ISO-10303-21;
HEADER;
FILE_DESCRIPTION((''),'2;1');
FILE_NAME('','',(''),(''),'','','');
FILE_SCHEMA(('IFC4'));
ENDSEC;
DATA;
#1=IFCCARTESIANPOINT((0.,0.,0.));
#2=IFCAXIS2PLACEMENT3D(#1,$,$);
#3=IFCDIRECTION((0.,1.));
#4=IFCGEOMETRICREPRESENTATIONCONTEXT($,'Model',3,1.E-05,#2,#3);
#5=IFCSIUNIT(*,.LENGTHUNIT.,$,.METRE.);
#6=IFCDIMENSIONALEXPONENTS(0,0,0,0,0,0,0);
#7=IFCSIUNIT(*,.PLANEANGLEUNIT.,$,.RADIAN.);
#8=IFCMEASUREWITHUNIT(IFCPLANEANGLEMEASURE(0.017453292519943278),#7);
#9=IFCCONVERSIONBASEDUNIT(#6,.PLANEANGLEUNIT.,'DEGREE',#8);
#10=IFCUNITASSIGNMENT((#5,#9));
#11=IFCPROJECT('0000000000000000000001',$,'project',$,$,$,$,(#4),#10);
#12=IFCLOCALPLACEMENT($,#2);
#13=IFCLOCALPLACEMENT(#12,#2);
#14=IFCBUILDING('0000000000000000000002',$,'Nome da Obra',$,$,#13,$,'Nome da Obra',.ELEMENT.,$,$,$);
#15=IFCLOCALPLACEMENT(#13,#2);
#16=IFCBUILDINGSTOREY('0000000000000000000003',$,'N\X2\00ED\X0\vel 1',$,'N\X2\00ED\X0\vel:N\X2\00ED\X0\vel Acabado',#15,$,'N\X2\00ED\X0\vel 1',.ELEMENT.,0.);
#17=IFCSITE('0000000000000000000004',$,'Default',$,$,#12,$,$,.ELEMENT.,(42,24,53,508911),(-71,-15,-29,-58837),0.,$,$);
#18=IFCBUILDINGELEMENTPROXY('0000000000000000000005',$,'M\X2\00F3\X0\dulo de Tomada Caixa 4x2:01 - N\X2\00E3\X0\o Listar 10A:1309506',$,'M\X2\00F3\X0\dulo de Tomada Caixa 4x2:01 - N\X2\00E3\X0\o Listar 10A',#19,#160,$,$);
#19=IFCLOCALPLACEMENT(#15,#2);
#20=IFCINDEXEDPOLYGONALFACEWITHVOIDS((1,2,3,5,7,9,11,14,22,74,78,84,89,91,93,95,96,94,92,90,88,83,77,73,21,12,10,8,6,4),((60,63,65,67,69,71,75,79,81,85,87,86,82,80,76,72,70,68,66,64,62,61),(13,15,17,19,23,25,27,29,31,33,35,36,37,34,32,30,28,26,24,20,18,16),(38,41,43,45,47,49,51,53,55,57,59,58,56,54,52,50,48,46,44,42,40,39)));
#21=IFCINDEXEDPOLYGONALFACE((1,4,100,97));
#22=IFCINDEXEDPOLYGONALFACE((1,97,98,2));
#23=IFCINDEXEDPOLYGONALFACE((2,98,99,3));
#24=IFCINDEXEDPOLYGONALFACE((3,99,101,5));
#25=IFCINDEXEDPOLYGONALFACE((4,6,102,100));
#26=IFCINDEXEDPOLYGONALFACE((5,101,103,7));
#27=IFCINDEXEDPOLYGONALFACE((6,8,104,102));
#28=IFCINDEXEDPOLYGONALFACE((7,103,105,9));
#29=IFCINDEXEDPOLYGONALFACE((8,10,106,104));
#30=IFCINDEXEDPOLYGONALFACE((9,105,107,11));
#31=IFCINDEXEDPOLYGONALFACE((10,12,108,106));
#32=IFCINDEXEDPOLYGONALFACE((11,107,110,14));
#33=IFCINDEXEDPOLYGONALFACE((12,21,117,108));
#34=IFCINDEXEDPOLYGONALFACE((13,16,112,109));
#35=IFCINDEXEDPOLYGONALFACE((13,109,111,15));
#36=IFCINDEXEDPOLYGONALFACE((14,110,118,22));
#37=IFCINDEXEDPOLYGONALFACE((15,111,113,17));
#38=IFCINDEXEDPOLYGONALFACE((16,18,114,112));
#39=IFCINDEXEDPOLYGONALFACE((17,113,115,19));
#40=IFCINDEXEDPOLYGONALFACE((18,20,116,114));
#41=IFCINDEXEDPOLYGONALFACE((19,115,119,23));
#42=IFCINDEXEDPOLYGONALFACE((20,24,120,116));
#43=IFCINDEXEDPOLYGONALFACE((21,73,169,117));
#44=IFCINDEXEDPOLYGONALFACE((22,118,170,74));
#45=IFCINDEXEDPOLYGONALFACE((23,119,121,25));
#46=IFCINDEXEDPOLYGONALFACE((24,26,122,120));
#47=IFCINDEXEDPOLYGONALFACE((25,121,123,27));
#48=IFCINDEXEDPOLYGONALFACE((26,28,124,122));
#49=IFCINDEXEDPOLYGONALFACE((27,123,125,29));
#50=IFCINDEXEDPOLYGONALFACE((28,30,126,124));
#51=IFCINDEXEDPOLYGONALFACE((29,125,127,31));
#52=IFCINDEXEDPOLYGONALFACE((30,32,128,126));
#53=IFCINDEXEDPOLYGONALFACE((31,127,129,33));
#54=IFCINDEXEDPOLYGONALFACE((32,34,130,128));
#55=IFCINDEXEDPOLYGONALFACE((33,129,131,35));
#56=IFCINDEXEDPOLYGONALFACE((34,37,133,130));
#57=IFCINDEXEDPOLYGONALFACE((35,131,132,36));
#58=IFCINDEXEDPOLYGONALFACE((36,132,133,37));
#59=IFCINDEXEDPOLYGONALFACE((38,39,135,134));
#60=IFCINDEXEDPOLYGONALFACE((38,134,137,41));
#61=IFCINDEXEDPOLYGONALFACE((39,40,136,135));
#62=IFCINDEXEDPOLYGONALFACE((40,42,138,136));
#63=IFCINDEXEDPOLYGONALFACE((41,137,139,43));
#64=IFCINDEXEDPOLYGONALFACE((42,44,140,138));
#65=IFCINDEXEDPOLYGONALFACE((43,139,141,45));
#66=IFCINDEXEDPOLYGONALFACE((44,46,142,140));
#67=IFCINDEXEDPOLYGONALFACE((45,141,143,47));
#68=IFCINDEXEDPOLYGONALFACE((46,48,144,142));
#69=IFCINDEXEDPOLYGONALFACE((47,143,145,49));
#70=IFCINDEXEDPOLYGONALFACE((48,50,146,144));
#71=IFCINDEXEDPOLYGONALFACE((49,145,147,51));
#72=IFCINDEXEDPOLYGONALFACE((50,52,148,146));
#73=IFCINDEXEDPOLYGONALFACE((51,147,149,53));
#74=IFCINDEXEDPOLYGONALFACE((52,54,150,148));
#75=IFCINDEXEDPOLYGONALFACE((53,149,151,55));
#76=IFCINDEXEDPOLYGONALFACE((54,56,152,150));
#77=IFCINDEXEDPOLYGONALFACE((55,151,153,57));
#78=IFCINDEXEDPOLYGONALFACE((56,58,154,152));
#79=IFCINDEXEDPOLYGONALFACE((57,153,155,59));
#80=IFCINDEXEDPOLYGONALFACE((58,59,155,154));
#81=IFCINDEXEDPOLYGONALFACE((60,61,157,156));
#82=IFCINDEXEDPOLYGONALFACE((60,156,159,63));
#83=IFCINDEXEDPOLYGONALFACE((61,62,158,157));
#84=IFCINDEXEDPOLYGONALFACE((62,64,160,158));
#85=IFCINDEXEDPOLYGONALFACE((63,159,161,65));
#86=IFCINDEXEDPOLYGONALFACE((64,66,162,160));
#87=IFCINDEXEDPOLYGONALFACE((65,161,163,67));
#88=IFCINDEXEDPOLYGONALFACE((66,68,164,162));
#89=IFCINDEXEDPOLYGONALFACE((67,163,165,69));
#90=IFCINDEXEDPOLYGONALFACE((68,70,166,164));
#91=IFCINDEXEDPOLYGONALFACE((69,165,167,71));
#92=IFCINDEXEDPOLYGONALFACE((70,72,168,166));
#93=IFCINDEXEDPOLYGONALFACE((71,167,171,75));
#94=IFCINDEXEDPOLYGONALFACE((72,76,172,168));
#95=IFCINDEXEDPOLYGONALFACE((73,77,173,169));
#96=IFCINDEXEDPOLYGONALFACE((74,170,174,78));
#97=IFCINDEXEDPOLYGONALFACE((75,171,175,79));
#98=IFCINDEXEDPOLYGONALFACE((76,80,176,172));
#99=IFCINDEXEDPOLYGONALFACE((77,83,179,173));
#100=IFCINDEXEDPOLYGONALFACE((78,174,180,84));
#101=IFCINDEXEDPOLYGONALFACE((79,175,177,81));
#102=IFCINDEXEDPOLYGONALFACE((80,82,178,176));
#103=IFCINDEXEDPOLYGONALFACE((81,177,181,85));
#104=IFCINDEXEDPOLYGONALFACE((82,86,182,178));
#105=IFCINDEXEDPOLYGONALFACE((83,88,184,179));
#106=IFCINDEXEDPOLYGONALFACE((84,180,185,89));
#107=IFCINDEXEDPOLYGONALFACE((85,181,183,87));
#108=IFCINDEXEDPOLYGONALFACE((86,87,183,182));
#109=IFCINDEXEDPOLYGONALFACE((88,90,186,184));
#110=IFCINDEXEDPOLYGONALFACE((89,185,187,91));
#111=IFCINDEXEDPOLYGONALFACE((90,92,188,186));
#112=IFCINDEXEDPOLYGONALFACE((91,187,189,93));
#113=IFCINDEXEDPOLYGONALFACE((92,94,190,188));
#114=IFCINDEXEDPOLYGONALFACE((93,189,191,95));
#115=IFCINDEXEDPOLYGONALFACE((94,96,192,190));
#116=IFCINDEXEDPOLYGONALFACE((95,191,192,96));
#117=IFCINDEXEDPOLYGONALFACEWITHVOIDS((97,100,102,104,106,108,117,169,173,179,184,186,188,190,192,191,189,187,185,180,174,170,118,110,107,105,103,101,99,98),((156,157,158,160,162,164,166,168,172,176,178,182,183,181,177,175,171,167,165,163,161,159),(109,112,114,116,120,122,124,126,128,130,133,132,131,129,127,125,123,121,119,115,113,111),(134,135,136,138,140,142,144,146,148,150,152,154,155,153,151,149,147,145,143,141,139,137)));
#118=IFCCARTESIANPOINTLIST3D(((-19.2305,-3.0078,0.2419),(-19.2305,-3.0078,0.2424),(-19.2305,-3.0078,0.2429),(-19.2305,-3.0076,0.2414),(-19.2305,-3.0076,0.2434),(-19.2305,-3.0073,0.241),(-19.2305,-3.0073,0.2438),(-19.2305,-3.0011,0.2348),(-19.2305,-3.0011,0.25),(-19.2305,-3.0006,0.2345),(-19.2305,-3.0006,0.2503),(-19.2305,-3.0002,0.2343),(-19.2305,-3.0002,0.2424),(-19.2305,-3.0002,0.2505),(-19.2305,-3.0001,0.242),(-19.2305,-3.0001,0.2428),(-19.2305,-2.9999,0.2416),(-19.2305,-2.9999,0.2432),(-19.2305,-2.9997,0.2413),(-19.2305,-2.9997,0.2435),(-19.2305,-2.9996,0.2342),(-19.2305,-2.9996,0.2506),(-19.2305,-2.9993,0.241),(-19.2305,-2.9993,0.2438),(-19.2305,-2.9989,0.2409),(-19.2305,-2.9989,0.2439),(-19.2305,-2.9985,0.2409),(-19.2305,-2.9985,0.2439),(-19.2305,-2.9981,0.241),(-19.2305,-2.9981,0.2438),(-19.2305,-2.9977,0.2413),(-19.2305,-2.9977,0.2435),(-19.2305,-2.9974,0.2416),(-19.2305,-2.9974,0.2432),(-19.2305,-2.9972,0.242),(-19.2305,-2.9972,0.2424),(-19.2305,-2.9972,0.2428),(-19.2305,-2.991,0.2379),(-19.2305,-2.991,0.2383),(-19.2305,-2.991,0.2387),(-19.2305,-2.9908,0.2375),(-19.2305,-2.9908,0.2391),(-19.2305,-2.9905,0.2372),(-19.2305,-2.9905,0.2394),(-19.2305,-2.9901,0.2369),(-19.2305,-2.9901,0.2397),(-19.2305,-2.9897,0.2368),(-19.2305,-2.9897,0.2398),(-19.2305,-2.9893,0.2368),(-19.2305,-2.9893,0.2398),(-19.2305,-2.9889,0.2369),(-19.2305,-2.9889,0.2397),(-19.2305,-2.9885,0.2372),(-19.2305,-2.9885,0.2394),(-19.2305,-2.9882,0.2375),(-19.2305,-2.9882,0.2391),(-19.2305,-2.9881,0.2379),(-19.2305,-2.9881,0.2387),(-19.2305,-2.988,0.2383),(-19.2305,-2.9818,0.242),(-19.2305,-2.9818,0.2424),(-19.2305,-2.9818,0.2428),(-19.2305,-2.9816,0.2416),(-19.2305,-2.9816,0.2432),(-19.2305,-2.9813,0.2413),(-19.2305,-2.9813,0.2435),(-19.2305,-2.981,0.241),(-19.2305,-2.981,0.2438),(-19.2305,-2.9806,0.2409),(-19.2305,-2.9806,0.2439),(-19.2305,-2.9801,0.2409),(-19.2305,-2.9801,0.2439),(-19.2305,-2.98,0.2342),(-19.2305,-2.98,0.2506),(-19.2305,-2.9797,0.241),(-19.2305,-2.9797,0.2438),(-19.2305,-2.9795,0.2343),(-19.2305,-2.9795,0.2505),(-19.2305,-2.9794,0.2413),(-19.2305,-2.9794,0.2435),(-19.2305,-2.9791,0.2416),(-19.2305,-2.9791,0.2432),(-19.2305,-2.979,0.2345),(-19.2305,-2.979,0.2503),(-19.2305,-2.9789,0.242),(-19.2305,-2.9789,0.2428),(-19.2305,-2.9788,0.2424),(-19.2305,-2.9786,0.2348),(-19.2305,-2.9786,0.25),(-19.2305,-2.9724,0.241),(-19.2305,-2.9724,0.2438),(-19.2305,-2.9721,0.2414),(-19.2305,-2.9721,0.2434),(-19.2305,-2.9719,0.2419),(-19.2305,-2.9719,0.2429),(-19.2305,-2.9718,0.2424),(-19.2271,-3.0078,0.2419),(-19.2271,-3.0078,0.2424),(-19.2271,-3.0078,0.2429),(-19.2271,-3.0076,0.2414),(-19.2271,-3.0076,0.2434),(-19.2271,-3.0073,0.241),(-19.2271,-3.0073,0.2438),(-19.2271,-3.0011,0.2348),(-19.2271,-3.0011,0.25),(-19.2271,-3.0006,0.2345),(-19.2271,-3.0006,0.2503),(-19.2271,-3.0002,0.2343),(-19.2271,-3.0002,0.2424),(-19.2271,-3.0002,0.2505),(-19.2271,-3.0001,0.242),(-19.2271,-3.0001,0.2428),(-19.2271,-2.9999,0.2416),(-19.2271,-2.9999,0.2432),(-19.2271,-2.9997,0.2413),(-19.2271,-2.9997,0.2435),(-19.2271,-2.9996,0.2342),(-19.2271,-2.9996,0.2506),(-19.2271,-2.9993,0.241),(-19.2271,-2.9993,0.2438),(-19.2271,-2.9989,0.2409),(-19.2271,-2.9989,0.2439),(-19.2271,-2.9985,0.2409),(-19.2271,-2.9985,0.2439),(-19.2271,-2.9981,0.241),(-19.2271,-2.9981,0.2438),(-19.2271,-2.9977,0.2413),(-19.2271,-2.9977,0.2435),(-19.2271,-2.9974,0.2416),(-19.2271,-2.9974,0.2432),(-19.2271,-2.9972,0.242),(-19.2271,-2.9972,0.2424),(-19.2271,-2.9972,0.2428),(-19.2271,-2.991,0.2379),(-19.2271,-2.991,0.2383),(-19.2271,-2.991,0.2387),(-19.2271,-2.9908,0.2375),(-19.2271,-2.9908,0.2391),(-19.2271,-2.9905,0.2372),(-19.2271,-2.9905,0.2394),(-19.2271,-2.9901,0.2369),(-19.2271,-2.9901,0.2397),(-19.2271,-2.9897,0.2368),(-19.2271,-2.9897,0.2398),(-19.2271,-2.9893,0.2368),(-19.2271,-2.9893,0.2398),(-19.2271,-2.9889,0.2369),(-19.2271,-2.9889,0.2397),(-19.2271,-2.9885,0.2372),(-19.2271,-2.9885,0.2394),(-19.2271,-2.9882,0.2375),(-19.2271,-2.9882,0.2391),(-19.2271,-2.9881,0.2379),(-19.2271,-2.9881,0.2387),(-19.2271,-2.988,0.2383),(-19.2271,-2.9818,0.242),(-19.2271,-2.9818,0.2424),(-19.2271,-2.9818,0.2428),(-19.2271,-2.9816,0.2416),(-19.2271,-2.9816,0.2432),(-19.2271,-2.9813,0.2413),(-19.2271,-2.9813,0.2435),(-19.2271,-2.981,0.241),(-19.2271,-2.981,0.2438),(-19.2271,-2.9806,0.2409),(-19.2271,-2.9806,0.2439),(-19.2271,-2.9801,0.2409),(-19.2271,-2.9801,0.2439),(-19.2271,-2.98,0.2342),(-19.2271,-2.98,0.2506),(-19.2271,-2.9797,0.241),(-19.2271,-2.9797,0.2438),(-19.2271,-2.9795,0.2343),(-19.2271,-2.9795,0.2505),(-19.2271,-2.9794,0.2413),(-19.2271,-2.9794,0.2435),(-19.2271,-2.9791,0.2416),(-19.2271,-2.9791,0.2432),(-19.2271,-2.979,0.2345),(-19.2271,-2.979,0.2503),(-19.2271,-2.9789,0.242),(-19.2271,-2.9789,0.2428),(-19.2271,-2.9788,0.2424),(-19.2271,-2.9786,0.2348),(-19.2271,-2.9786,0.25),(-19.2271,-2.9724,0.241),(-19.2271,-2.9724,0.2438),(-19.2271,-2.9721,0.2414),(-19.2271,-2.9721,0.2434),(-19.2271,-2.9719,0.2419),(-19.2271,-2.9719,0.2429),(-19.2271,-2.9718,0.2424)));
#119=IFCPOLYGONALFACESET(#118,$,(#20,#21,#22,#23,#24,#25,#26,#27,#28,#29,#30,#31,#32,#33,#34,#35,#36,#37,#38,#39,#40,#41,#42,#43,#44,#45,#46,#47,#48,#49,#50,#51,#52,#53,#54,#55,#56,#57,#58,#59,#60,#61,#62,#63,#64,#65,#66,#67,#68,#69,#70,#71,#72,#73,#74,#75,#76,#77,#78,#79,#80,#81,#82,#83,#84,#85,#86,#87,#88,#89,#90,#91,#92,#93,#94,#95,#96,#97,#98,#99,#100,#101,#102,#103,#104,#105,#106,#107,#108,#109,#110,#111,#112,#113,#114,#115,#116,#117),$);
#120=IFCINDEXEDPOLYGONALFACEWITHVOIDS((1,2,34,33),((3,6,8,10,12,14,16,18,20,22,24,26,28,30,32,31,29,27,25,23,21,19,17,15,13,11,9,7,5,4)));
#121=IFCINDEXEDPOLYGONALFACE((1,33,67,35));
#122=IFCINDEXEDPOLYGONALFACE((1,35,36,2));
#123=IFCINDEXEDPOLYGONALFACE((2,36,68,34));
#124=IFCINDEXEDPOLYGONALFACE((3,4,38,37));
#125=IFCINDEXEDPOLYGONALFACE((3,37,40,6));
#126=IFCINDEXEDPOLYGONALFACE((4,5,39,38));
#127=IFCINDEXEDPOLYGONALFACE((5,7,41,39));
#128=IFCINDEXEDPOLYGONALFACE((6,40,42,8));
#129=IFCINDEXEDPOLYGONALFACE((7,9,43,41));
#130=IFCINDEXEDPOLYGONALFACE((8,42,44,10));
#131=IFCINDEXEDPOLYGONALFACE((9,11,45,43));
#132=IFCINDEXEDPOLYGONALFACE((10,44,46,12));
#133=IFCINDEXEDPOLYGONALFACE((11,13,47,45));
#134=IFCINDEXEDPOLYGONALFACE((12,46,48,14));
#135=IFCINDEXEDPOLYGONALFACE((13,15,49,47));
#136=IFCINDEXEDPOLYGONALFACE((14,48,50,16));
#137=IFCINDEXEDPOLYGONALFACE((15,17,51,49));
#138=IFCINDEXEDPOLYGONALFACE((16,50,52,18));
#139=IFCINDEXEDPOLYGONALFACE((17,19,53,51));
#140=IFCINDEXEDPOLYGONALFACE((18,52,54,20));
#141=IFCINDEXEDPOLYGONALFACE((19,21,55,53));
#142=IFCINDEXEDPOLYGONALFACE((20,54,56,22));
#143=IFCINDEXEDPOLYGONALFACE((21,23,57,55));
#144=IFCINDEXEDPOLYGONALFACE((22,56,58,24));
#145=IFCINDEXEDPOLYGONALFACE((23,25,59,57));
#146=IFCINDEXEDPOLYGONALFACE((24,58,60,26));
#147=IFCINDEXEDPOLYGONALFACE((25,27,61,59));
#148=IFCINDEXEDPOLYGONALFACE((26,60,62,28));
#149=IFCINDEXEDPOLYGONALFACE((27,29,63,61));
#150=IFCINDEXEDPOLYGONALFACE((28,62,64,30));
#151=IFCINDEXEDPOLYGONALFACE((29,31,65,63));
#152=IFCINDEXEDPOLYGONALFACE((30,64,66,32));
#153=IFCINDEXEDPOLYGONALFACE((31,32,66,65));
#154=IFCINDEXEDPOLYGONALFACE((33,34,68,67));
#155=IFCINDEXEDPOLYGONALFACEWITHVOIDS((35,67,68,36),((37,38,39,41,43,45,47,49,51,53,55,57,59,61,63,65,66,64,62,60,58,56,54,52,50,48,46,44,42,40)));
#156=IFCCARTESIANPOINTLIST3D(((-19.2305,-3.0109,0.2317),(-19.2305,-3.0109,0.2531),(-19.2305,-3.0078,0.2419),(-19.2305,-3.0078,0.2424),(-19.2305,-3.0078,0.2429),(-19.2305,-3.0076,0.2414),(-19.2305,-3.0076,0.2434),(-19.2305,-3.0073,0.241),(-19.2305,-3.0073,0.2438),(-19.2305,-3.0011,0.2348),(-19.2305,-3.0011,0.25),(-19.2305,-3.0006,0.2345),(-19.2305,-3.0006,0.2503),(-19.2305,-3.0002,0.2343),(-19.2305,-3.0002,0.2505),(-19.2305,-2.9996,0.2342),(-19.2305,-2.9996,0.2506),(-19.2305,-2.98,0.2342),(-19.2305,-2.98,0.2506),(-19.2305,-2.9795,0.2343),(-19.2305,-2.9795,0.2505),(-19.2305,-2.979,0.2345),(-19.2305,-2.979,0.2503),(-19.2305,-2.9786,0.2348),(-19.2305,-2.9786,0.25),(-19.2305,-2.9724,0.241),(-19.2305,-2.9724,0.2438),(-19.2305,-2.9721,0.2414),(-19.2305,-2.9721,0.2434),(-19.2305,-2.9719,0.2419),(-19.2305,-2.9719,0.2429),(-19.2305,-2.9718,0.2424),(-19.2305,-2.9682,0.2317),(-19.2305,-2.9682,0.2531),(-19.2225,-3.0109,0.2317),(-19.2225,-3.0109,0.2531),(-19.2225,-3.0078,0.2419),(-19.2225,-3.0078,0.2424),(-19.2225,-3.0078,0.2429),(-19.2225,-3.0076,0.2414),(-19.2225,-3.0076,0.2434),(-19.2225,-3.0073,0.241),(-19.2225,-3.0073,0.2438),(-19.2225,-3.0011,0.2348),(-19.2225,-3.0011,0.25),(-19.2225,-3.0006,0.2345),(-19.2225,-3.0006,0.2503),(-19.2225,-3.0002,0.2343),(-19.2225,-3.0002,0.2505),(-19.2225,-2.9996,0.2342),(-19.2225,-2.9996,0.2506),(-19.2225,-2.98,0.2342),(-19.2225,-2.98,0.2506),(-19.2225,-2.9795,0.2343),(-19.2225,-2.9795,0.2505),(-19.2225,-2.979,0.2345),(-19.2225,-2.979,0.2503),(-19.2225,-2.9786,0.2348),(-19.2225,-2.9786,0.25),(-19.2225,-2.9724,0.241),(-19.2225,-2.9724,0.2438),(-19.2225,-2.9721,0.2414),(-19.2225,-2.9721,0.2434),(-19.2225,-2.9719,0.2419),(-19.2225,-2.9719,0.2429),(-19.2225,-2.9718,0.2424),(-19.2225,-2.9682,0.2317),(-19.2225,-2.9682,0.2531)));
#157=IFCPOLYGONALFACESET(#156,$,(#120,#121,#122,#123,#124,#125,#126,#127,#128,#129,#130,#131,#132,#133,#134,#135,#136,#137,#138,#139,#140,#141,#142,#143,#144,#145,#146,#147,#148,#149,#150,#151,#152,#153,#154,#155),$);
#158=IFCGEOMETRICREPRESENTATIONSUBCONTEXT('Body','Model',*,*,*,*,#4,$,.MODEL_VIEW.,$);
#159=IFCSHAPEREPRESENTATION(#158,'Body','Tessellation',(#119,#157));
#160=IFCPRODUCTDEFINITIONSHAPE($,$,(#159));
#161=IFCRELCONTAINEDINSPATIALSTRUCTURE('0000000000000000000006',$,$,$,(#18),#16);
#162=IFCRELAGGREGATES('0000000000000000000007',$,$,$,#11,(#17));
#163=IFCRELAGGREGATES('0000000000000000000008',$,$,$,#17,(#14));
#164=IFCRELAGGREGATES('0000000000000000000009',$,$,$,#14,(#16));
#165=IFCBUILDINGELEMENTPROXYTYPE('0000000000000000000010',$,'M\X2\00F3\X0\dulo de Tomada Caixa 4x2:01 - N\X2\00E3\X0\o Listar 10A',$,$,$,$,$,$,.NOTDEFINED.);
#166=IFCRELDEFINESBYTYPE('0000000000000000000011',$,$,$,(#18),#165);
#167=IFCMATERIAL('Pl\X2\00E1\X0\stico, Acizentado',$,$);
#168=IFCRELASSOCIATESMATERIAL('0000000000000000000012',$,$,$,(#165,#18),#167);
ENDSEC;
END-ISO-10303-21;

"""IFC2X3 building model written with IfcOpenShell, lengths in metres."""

from ifc_helpers import new_model, entity, si_unit, converted_unit, direction, frame, frame_2d, origin, place, context, subcontext, project, spatial, polyline, circle_curve, parameter, trimmed, segment, composite_curve, outline, extrude, source, transform, mapped, material, type_object, type_shapes, element, save


model = new_model("IFC2X3")

# Units and contexts
model_context = context("Model", 3, precision=1e-05, world=origin(), true_north=direction((0.0, 1.0)))
body_context = subcontext(model_context, "Body", "Model", "MODEL_VIEW")
ifc_project = project(units=[si_unit("LENGTHUNIT", "METRE"), converted_unit("PLANEANGLEUNIT", "DEGREE", entity("IfcPlaneAngleMeasure", 0.017453292519943278), si_unit("PLANEANGLEUNIT", "RADIAN"), dimensions=[0, 0, 0, 0, 0, 0, 0])], contexts=[model_context])

# Site, building, storey
site_placement = place(None, origin())
site = spatial("IfcSite", under=ifc_project, at=site_placement, Name="Default", CompositionType="ELEMENT", RefLatitude=(42, 24, 53, 508911), RefLongitude=(-71, -15, -29, -58837), RefElevation=0.0)
building_placement = place(site_placement, origin())
building = spatial("IfcBuilding", under=site, at=building_placement, Name="Nome da Obra", LongName="Nome da Obra", CompositionType="ELEMENT")
storey_placement = place(building_placement, origin())
storey = spatial("IfcBuildingStorey", under=building, at=storey_placement, Name="Nível 1", ObjectType="Nível:Nível Acabado", LongName="Nível 1", CompositionType="ELEMENT", Elevation=0.0)

# Building element proxy
ifc_material_1 = material(Name="Plástico, Acizentado")
building_element_proxy_type_1 = type_object("IfcBuildingElementProxyType", Name="Módulo de Tomada Caixa 4x2:01 - Não Listar 10A", PredefinedType="NOTDEFINED", material=ifc_material_1)
shared_shape_1 = source(origin(), body_context, "Body", "SweptSolid", [
    extrude(outline(composite_curve([segment(polyline([(-0.0098, -0.0082), (0.0098, -0.0082)]), True, "CONTINUOUS"), segment(trimmed(circle_curve(frame_2d((0.0098, -0.0062), x_axis=(1.0, 0.0)), 0.002), [parameter(270.0)], [parameter(315.0)], True, "PARAMETER"), True, "CONTINUOUS"), segment(polyline([(0.0112, -0.0076), (0.0174, -0.0014)]), True, "CONTINUOUS"), segment(trimmed(circle_curve(frame_2d((0.016, 0.0), x_axis=(1.0, 0.0)), 0.002), [parameter(315.0)], [parameter(45.0)], True, "PARAMETER"), True, "CONTINUOUS"), segment(polyline([(0.0174, 0.0014), (0.0112, 0.0076)]), True, "CONTINUOUS"), segment(trimmed(circle_curve(frame_2d((0.0098, 0.0062), x_axis=(1.0, 0.0)), 0.002), [parameter(45.0)], [parameter(90.0)], True, "PARAMETER"), True, "CONTINUOUS"), segment(polyline([(0.0098, 0.0082), (-0.0098, 0.0082)]), True, "CONTINUOUS"), segment(trimmed(circle_curve(frame_2d((-0.0098, 0.0062), x_axis=(1.0, 0.0)), 0.002), [parameter(90.0)], [parameter(135.0)], True, "PARAMETER"), True, "CONTINUOUS"), segment(polyline([(-0.0112, 0.0076), (-0.0174, 0.0014)]), True, "CONTINUOUS"), segment(trimmed(circle_curve(frame_2d((-0.016, 0.0), x_axis=(1.0, 0.0)), 0.002), [parameter(135.0)], [parameter(225.0)], True, "PARAMETER"), True, "CONTINUOUS"), segment(polyline([(-0.0174, -0.0014), (-0.0112, -0.0076)]), True, "CONTINUOUS"), segment(trimmed(circle_curve(frame_2d((-0.0098, -0.0062), x_axis=(1.0, 0.0)), 0.002), [parameter(225.0)], [parameter(270.0)], True, "PARAMETER"), True, "CONTINUOUS")], self_intersect=False), holes=[composite_curve([segment(trimmed(circle_curve(frame_2d((0.0089, 0.0), x_axis=(1.0, 0.0)), 0.0015), [parameter(0.0)], [parameter(180.0)], True, "PARAMETER"), False, "CONTINUOUS"), segment(trimmed(circle_curve(frame_2d((0.0089, 0.0), x_axis=(1.0, 0.0)), 0.0015), [parameter(180.0)], [parameter(0.0)], True, "PARAMETER"), False, "CONTINUOUS")], self_intersect=False), composite_curve([segment(trimmed(circle_curve(frame_2d((-0.0003, 0.0041), x_axis=(1.0, 0.0)), 0.0015), [parameter(0.0)], [parameter(180.0)], True, "PARAMETER"), False, "CONTINUOUS"), segment(trimmed(circle_curve(frame_2d((-0.0003, 0.0041), x_axis=(1.0, 0.0)), 0.0015), [parameter(180.0)], [parameter(0.0)], True, "PARAMETER"), False, "CONTINUOUS")], self_intersect=False), composite_curve([segment(trimmed(circle_curve(frame_2d((-0.0095, 0.0), x_axis=(1.0, 0.0)), 0.0015), [parameter(0.0)], [parameter(180.0)], True, "PARAMETER"), False, "CONTINUOUS"), segment(trimmed(circle_curve(frame_2d((-0.0095, 0.0), x_axis=(1.0, 0.0)), 0.0015), [parameter(180.0)], [parameter(0.0)], True, "PARAMETER"), False, "CONTINUOUS")], self_intersect=False)]), frame((0.0003, 0.0, 0.125), z_axis=(0.0, 1.0, 0.0), x_axis=(1.0, 0.0, 0.0)), (0.0, 0.0, 1.0), 0.0034),
    extrude(outline(polyline([(-0.0214, -0.0107), (0.0214, -0.0107), (0.0214, 0.0107), (-0.0214, 0.0107), (-0.0214, -0.0107)]), holes=[composite_curve([segment(polyline([(0.0101, -0.0082), (-0.0095, -0.0082)]), True, "CONTINUOUS"), segment(trimmed(circle_curve(frame_2d((-0.0095, -0.0062), x_axis=(1.0, 0.0)), 0.002), [parameter(225.0)], [parameter(270.0)], True, "PARAMETER"), False, "CONTINUOUS"), segment(polyline([(-0.0109, -0.0076), (-0.0171, -0.0014)]), True, "CONTINUOUS"), segment(trimmed(circle_curve(frame_2d((-0.0157, 0.0), x_axis=(1.0, 0.0)), 0.002), [parameter(135.0)], [parameter(225.0)], True, "PARAMETER"), False, "CONTINUOUS"), segment(polyline([(-0.0171, 0.0014), (-0.0109, 0.0076)]), True, "CONTINUOUS"), segment(trimmed(circle_curve(frame_2d((-0.0095, 0.0062), x_axis=(1.0, 0.0)), 0.002), [parameter(90.0)], [parameter(135.0)], True, "PARAMETER"), False, "CONTINUOUS"), segment(polyline([(-0.0095, 0.0082), (0.0101, 0.0082)]), True, "CONTINUOUS"), segment(trimmed(circle_curve(frame_2d((0.0101, 0.0062), x_axis=(1.0, 0.0)), 0.002), [parameter(45.0)], [parameter(90.0)], True, "PARAMETER"), False, "CONTINUOUS"), segment(polyline([(0.0115, 0.0076), (0.0177, 0.0014)]), True, "CONTINUOUS"), segment(trimmed(circle_curve(frame_2d((0.0163, 0.0), x_axis=(1.0, 0.0)), 0.002), [parameter(315.0)], [parameter(45.0)], True, "PARAMETER"), False, "CONTINUOUS"), segment(polyline([(0.0177, -0.0014), (0.0115, -0.0076)]), True, "CONTINUOUS"), segment(trimmed(circle_curve(frame_2d((0.0101, -0.0062), x_axis=(1.0, 0.0)), 0.002), [parameter(270.0)], [parameter(315.0)], True, "PARAMETER"), False, "CONTINUOUS")], self_intersect=False)]), frame((0.0, 0.0, 0.125), z_axis=(0.0, 1.0, 0.0), x_axis=(1.0, 0.0, 0.0)), (0.0, 0.0, 1.0), 0.008),
])
type_shapes(building_element_proxy_type_1, [shared_shape_1])
for number, where, z_axis, x_axis, name in (
    (1, (-19.2305, -2.9895, 0.1174), (0.0, 0.0, 1.0), (0.0, -1.0, 0.0), "Módulo de Tomada Caixa 4x2:01 - Não Listar 10A:1309506"),
):
    element("IfcBuildingElementProxy", number, at=place(storey_placement, frame(where, z_axis=z_axis, x_axis=x_axis)), inside=storey, type_object=building_element_proxy_type_1, material=ifc_material_1, Name=name, ObjectType="Módulo de Tomada Caixa 4x2:01 - Não Listar 10A", context=body_context, shape_type="MappedRepresentation", body=[
        mapped(shared_shape_1, transform((0.0, 0.0, 0.0), scale=1.0)),
    ])

save(model, "model.ifc")
